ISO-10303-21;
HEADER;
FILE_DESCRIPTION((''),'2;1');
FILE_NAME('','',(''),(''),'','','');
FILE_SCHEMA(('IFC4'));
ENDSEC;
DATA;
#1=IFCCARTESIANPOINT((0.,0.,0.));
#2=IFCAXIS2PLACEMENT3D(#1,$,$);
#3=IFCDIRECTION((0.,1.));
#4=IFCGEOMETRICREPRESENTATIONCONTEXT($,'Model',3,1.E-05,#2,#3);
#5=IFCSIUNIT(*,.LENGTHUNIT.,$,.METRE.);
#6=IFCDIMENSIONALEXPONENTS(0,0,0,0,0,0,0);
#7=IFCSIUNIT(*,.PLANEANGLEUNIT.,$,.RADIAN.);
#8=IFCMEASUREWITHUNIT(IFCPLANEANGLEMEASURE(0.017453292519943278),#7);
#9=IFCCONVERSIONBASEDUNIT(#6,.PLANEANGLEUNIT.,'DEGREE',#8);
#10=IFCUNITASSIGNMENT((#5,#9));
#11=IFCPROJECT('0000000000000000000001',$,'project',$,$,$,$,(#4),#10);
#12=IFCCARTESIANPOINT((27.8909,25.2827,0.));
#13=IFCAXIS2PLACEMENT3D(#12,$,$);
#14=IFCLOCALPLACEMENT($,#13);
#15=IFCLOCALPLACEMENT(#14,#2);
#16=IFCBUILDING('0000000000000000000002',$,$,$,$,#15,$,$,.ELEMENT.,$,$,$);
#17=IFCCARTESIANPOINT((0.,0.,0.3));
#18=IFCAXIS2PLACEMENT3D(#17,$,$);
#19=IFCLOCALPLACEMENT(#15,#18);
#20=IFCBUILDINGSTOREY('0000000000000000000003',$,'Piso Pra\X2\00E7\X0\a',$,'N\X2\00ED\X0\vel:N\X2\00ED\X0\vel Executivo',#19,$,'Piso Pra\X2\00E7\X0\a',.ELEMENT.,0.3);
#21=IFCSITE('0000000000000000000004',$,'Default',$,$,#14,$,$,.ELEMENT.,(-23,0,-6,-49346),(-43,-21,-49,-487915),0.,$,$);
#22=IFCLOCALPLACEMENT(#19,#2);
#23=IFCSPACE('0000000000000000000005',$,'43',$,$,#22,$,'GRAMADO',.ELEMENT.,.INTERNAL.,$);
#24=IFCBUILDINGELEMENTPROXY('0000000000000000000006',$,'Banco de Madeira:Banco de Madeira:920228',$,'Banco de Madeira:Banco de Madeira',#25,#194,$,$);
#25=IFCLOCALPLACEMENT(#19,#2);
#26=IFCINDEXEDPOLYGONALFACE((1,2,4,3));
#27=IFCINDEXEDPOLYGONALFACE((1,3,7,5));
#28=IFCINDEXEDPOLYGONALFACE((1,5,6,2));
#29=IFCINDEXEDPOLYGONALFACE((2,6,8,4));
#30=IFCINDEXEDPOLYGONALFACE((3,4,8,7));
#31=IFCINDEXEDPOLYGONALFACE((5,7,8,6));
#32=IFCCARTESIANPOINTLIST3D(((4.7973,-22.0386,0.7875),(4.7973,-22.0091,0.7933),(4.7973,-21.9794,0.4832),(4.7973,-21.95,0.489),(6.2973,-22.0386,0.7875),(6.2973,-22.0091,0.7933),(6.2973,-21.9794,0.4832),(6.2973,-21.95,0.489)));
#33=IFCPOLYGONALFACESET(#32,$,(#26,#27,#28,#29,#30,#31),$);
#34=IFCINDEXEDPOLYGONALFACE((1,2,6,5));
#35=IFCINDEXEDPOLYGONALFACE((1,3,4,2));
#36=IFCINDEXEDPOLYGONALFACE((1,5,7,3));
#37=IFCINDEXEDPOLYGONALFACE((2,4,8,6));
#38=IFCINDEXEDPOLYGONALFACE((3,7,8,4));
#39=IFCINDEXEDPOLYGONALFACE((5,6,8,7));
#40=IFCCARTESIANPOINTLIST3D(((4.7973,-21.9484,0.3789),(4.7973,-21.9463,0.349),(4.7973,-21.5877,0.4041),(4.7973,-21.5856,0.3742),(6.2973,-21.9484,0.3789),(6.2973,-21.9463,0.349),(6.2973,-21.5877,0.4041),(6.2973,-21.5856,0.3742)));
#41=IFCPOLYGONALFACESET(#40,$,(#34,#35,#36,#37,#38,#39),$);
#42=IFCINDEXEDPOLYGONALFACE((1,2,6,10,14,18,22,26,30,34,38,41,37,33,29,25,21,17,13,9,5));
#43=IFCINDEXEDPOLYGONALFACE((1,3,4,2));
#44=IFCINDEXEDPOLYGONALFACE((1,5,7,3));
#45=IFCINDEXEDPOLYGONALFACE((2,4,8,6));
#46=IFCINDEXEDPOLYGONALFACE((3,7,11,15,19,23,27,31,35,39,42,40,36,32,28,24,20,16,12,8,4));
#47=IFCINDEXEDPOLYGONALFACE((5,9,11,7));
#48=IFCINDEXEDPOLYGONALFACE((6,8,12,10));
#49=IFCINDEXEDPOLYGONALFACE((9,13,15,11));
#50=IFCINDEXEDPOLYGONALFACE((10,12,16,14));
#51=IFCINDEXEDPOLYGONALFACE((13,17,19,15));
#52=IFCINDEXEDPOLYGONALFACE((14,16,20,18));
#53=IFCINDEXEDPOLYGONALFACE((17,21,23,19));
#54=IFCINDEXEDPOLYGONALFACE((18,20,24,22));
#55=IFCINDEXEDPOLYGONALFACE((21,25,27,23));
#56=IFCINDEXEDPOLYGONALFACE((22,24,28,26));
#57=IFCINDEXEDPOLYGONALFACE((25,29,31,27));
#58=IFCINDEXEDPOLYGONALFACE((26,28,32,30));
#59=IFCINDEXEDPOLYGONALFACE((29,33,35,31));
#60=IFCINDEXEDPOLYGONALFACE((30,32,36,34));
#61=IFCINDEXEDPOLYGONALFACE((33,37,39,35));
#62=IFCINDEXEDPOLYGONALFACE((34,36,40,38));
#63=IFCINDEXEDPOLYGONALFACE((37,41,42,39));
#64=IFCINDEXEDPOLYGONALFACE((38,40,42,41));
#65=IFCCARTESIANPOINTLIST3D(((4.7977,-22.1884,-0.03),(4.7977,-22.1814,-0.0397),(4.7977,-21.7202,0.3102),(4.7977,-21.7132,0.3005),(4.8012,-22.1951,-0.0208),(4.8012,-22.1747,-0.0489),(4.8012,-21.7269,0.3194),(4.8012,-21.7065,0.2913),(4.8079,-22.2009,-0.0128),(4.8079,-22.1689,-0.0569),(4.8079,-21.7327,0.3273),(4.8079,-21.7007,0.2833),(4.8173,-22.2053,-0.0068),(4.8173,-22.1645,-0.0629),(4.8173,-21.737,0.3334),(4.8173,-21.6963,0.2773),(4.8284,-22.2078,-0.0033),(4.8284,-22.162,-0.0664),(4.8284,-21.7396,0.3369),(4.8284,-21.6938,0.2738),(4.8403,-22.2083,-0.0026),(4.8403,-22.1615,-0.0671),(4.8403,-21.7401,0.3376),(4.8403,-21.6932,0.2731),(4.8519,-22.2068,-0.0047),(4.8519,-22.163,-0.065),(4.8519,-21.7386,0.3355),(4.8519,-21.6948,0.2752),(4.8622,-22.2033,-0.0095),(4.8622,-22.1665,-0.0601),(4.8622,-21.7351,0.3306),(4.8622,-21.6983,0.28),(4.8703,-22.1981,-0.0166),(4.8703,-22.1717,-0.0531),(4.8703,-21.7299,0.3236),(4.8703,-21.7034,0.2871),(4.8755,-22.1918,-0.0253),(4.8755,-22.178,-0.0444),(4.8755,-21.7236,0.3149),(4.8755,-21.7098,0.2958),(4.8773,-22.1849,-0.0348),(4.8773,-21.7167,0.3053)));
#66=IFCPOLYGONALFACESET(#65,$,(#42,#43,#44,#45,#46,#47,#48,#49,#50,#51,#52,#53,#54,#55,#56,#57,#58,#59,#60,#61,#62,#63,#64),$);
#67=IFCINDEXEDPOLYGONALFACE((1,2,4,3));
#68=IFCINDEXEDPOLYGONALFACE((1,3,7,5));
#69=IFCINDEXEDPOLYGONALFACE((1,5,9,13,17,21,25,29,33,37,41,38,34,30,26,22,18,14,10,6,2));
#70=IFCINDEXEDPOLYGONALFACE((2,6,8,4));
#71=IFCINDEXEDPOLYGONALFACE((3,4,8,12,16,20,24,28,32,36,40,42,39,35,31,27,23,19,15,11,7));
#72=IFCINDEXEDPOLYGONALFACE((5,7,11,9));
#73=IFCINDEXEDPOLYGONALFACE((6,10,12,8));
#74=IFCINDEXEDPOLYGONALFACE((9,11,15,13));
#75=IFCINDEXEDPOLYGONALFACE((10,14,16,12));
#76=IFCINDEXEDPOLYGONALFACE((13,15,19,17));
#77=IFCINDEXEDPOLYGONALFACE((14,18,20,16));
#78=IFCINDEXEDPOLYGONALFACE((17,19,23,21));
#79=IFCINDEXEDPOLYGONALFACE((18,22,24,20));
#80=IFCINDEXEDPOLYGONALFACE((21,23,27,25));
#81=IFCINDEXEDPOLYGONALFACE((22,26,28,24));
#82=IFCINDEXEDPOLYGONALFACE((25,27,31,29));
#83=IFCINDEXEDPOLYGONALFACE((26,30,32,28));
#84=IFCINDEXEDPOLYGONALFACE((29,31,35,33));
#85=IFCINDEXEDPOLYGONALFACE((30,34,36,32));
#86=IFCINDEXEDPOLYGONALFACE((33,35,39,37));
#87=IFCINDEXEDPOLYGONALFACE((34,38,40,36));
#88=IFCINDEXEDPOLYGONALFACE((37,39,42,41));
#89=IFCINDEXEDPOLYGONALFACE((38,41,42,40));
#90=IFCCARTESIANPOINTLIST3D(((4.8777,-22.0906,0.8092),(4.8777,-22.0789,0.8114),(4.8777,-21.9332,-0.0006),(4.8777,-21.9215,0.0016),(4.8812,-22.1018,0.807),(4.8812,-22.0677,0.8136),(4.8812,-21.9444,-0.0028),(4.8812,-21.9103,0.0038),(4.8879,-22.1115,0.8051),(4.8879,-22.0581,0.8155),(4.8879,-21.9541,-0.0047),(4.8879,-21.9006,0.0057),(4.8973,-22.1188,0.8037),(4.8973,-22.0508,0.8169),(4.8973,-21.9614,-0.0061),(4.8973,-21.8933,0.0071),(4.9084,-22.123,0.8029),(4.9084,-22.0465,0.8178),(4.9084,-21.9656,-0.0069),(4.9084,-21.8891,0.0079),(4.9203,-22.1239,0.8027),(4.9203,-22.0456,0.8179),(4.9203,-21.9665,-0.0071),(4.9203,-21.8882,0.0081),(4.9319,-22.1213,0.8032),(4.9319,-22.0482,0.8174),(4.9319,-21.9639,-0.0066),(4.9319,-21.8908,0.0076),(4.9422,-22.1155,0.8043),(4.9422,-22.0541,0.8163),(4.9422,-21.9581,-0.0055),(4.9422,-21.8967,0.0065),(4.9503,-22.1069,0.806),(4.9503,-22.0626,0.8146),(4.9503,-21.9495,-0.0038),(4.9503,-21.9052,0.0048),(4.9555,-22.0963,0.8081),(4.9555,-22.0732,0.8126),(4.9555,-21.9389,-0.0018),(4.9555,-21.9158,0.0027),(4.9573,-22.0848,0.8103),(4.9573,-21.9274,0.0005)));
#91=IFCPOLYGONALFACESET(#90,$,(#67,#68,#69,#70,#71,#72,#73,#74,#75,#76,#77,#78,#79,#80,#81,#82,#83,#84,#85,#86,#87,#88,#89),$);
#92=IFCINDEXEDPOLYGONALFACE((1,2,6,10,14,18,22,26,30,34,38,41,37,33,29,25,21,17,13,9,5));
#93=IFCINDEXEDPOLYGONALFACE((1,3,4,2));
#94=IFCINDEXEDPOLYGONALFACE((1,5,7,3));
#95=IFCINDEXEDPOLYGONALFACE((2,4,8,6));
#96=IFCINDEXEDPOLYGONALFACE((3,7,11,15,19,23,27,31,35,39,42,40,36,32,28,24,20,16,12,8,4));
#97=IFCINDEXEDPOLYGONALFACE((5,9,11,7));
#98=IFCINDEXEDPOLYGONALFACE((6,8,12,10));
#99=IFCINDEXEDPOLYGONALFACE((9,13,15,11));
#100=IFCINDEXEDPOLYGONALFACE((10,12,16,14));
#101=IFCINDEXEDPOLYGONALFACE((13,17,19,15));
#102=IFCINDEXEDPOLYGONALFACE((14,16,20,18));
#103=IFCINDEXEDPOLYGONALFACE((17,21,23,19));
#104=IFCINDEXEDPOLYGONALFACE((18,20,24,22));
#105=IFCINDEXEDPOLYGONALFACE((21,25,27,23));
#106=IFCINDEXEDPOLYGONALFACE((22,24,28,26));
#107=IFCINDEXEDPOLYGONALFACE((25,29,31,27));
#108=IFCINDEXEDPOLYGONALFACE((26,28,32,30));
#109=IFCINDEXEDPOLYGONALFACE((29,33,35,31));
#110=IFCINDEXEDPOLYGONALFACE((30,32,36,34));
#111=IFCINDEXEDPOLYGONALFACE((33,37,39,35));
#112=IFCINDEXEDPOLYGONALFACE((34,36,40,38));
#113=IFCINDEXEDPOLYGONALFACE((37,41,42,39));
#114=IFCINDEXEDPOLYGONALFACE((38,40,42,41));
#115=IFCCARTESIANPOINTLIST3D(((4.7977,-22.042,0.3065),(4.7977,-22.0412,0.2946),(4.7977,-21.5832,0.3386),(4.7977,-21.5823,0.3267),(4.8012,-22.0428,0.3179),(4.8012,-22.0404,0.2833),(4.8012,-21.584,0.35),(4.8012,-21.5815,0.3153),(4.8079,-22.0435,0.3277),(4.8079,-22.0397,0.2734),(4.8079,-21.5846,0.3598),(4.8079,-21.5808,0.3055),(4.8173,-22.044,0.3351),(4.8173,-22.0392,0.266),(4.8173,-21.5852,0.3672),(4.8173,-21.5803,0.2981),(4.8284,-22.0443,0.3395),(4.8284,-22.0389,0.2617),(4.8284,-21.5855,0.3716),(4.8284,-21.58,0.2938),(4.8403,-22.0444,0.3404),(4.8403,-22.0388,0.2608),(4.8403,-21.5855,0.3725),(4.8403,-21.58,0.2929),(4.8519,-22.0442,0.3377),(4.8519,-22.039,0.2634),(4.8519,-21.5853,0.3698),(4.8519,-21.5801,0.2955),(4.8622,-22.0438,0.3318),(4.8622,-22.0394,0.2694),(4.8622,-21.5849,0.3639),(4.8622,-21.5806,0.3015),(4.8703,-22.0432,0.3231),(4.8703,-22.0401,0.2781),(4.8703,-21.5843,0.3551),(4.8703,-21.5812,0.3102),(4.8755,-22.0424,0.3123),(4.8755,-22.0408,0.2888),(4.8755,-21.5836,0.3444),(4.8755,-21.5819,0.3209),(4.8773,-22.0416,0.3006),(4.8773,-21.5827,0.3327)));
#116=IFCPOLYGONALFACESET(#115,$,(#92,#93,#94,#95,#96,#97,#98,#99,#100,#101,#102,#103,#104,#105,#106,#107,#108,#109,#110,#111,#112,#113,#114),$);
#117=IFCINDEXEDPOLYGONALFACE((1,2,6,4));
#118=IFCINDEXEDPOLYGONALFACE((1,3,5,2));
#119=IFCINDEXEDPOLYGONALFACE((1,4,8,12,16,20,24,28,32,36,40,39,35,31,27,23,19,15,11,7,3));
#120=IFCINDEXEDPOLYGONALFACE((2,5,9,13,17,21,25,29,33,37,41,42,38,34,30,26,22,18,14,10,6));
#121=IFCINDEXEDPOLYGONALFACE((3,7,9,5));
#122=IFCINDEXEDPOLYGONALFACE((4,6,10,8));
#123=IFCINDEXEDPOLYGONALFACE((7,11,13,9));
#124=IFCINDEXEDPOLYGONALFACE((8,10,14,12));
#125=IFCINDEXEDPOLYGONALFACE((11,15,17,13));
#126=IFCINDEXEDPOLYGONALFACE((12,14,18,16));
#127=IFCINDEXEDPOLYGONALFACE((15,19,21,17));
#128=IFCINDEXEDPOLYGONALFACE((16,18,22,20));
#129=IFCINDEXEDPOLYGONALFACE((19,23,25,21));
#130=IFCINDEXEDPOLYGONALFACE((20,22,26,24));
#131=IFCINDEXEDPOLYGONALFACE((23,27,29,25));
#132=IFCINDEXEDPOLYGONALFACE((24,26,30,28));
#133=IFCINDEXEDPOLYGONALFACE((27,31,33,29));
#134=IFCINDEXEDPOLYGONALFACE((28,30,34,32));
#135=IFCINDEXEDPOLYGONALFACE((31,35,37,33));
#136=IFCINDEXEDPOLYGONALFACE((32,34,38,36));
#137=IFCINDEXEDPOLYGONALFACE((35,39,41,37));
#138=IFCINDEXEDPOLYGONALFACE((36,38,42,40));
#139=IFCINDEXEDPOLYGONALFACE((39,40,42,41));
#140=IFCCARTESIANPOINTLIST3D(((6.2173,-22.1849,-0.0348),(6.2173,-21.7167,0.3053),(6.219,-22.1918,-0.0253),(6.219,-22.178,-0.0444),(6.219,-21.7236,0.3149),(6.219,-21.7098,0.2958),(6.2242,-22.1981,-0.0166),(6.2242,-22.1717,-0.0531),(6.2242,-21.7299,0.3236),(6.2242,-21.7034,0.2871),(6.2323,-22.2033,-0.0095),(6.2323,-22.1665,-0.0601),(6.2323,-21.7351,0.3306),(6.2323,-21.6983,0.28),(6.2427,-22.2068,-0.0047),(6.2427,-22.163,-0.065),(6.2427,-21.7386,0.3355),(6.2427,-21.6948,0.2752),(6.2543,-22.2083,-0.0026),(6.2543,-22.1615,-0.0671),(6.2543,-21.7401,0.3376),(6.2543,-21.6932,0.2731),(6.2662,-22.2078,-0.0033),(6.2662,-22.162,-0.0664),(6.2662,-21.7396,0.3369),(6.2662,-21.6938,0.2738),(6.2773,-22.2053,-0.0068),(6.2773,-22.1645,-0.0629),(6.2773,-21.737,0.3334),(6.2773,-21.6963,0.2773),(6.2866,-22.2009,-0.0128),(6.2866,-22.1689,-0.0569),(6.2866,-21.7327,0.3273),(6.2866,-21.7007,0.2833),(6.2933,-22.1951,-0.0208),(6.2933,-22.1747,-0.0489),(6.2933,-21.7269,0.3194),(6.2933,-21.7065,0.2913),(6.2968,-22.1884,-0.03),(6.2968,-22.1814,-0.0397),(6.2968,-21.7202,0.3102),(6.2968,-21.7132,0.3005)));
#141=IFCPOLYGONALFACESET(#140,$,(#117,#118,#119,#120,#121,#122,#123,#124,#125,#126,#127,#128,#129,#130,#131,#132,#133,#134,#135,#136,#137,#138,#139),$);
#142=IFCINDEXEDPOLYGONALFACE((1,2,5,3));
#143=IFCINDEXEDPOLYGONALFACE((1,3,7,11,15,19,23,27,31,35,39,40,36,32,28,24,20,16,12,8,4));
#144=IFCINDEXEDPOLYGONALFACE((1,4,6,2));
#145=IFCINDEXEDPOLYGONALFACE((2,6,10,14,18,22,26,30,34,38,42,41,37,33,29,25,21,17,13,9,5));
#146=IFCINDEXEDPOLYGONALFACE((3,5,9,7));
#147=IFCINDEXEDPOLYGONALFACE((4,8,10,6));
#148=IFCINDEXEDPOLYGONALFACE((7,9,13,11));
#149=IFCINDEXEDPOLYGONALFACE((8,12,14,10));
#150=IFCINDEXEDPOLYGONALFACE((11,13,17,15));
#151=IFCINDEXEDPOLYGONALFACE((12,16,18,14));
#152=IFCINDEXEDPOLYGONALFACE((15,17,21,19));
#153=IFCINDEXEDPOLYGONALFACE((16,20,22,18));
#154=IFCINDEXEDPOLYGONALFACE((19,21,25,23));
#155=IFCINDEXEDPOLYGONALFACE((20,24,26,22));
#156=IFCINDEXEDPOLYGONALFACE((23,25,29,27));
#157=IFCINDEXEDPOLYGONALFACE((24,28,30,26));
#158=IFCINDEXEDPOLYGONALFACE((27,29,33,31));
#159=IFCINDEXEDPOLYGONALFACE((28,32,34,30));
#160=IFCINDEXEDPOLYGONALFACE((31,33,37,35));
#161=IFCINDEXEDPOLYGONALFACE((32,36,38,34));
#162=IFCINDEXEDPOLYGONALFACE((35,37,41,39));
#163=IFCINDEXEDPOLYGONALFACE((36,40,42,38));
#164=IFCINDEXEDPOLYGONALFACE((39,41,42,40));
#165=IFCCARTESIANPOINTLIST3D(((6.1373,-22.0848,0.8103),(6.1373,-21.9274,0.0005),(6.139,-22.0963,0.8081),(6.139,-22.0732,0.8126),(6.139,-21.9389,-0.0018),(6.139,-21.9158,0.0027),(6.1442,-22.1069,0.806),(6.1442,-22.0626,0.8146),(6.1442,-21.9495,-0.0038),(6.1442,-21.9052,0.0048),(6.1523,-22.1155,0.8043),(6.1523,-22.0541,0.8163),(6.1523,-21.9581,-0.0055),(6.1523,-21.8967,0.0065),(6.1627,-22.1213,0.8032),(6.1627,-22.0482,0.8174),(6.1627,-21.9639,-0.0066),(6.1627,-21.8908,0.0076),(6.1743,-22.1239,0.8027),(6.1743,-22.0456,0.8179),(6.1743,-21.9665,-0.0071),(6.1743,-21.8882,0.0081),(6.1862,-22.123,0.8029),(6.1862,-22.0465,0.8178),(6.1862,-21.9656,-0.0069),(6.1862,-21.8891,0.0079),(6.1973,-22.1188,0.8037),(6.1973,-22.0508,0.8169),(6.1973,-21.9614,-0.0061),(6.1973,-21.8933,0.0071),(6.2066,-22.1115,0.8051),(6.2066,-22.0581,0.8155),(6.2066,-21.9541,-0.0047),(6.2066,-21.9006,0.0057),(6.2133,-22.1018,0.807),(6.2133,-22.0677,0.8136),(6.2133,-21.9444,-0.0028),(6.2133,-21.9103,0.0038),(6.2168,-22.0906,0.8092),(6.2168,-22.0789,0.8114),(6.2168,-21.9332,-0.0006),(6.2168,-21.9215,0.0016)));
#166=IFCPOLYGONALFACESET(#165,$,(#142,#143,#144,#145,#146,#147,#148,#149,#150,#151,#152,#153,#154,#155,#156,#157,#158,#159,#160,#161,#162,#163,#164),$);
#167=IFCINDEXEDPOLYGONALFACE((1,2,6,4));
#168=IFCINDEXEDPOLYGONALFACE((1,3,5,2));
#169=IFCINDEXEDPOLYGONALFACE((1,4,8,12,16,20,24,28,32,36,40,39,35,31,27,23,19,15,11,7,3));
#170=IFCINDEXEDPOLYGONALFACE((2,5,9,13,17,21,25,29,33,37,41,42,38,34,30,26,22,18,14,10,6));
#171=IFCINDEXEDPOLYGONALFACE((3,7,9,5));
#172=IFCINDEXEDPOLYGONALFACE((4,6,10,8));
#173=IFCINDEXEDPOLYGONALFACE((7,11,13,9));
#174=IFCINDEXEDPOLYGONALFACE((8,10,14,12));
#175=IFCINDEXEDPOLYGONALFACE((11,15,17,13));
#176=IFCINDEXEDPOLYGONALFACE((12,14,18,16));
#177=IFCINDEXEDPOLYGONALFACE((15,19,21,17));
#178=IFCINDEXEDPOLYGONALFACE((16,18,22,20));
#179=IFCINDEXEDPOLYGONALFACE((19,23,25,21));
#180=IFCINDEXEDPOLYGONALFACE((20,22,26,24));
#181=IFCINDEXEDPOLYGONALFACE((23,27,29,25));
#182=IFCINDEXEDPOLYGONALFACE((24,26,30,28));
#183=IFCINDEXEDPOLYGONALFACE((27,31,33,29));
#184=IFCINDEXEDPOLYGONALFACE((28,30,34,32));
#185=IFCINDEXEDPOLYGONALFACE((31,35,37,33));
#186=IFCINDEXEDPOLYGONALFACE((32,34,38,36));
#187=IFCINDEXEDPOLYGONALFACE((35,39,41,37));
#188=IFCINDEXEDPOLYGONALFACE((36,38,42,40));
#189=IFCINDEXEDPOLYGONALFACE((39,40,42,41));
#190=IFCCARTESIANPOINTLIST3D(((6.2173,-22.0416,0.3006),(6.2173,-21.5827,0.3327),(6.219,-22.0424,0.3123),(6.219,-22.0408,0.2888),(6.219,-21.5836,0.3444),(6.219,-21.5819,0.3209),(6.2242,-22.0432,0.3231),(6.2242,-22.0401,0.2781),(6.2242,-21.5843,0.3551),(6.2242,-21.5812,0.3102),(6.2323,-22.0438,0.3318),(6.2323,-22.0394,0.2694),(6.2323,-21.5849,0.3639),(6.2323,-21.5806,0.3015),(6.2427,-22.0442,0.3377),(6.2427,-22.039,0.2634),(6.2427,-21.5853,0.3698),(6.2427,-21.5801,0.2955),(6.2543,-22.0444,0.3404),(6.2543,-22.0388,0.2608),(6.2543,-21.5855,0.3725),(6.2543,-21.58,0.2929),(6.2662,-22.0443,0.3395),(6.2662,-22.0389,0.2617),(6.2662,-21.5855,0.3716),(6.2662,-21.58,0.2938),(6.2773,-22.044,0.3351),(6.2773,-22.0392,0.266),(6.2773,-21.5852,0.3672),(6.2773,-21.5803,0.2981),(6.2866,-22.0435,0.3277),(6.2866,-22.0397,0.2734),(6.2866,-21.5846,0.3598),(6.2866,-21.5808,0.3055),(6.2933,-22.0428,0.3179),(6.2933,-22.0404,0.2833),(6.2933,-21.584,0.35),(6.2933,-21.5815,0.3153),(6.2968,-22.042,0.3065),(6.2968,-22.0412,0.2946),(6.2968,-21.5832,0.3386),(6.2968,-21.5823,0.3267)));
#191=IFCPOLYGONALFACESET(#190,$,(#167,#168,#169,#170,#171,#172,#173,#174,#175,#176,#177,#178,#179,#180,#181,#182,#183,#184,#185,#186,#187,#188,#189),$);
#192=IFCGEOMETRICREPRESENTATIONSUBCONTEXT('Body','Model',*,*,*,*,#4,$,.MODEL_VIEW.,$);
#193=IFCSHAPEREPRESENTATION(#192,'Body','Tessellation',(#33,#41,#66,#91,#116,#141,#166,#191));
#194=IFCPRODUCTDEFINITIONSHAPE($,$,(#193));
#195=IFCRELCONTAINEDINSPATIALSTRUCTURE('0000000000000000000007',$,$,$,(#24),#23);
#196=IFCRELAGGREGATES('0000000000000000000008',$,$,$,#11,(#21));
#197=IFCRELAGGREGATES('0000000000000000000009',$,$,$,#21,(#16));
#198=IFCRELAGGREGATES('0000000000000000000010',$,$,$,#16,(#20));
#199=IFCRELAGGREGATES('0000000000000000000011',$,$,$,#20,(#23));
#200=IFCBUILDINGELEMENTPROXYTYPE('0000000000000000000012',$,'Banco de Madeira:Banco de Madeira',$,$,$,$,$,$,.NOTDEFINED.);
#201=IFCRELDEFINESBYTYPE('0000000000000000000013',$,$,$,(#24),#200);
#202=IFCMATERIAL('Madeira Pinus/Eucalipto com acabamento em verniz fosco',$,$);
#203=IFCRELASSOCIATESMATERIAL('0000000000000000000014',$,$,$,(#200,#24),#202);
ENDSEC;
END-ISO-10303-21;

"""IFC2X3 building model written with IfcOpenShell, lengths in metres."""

from ifc_helpers import new_model, entity, si_unit, converted_unit, direction, frame, frame_2d, origin, place, context, subcontext, project, spatial, rectangle, circle, extrude, source, transform, mapped, material, type_object, type_shapes, element, save


model = new_model("IFC2X3")

# Units and contexts
model_context = context("Model", 3, precision=1e-05, world=origin(), true_north=direction((0.0, 1.0)))
body_context = subcontext(model_context, "Body", "Model", "MODEL_VIEW")
ifc_project = project(units=[si_unit("LENGTHUNIT", "METRE"), converted_unit("PLANEANGLEUNIT", "DEGREE", entity("IfcPlaneAngleMeasure", 0.017453292519943278), si_unit("PLANEANGLEUNIT", "RADIAN"), dimensions=[0, 0, 0, 0, 0, 0, 0])], contexts=[model_context])

# Site, building, storey
site_placement = place(None, frame((27.8909, 25.2827, 0.0)))
site = spatial("IfcSite", under=ifc_project, at=site_placement, Name="Default", CompositionType="ELEMENT", RefLatitude=(-23, 0, -6, -49346), RefLongitude=(-43, -21, -49, -487915), RefElevation=0.0)
building_placement = place(site_placement, origin())
building = spatial("IfcBuilding", under=site, at=building_placement, CompositionType="ELEMENT")
storey_placement = place(building_placement, frame((0.0, 0.0, 0.3)))
storey = spatial("IfcBuildingStorey", under=building, at=storey_placement, Name="Piso Praça", ObjectType="Nível:Nível Executivo", LongName="Piso Praça", CompositionType="ELEMENT", Elevation=0.3)

# Shared definitions
space_1_placement = place(storey_placement, origin())
space_1 = spatial("IfcSpace", under=storey, at=space_1_placement, Name="43", LongName="GRAMADO", CompositionType="ELEMENT", InteriorOrExteriorSpace="INTERNAL")

# Building element proxy
ifc_material_1 = material(Name="Madeira Pinus/Eucalipto com acabamento em verniz fosco")
building_element_proxy_type_1 = type_object("IfcBuildingElementProxyType", Name="Banco de Madeira:Banco de Madeira", PredefinedType="NOTDEFINED", material=ifc_material_1)
shared_shape_1 = source(origin(), body_context, "Body", "SweptSolid", [
    extrude(rectangle(XDim=0.31, YDim=0.03, at=frame_2d((0.0, 0.0), x_axis=(1.0, 0.0))), frame((-0.75, 0.1439, 0.6383), z_axis=(1.0, 0.0, 0.0), x_axis=(0.0, 0.190809, 0.981627)), (0.0, 0.0, 1.0), 1.5),
    extrude(rectangle(XDim=0.03, YDim=0.3616, at=frame_2d((0.0, 0.0), x_axis=(0.0, 1.0))), frame((-0.75, -0.0833, 0.3765), z_axis=(1.0, 0.0, 0.0), x_axis=(0.0, 0.997564, -0.069756)), (0.0, 0.0, 1.0), 1.5),
    extrude(circle(Radius=0.04, at=frame_2d((0.0, 0.0), x_axis=(1.0, 0.0))), frame((0.71, 0.3345, -0.0348), z_axis=(0.0, -0.809017, 0.587785), x_axis=(-1.0, 0.0, 0.0)), (0.0, 0.0, 1.0), 0.5788),
    extrude(circle(Radius=0.04, at=frame_2d((0.0, 0.0), x_axis=(1.0, 0.0))), frame((0.63, 0.077, 0.0005), z_axis=(0.0, 0.190809, 0.981627), x_axis=(-1.0, 0.0, 0.0)), (0.0, 0.0, 1.0), 0.825),
    extrude(circle(Radius=0.04, at=frame_2d((0.0, 0.0), x_axis=(1.0, 0.0))), frame((0.71, -0.2676, 0.3327), z_axis=(0.0, 0.997564, -0.069756), x_axis=(-1.0, 0.0, 0.0)), (0.0, 0.0, 1.0), 0.46),
    extrude(circle(Radius=0.04, at=frame_2d((0.0, 0.0), x_axis=(1.0, 0.0))), frame((-0.71, 0.3345, -0.0348), z_axis=(0.0, -0.809017, 0.587785), x_axis=(1.0, 0.0, 0.0)), (0.0, 0.0, 1.0), 0.5788),
    extrude(circle(Radius=0.04, at=frame_2d((0.0, 0.0), x_axis=(1.0, 0.0))), frame((-0.63, 0.077, 0.0005), z_axis=(0.0, 0.190809, 0.981627), x_axis=(1.0, 0.0, 0.0)), (0.0, 0.0, 1.0), 0.825),
    extrude(circle(Radius=0.04, at=frame_2d((0.0, 0.0), x_axis=(1.0, 0.0))), frame((-0.71, -0.2676, 0.3327), z_axis=(0.0, 0.997564, -0.069756), x_axis=(1.0, 0.0, 0.0)), (0.0, 0.0, 1.0), 0.46),
])
type_shapes(building_element_proxy_type_1, [shared_shape_1])
for number, where, z_axis, x_axis, name in (
    (1, (5.5473, -21.8504, 0.0), (0.0, 0.0, 1.0), (-1.0, 0.0, 0.0), "Banco de Madeira:Banco de Madeira:920228"),
):
    element("IfcBuildingElementProxy", number, at=place(space_1_placement, frame(where, z_axis=z_axis, x_axis=x_axis)), inside=space_1, type_object=building_element_proxy_type_1, material=ifc_material_1, Name=name, ObjectType="Banco de Madeira:Banco de Madeira", context=body_context, shape_type="MappedRepresentation", body=[
        mapped(shared_shape_1, transform((0.0, 0.0, 0.0), scale=1.0)),
    ])

save(model, "model.ifc")
